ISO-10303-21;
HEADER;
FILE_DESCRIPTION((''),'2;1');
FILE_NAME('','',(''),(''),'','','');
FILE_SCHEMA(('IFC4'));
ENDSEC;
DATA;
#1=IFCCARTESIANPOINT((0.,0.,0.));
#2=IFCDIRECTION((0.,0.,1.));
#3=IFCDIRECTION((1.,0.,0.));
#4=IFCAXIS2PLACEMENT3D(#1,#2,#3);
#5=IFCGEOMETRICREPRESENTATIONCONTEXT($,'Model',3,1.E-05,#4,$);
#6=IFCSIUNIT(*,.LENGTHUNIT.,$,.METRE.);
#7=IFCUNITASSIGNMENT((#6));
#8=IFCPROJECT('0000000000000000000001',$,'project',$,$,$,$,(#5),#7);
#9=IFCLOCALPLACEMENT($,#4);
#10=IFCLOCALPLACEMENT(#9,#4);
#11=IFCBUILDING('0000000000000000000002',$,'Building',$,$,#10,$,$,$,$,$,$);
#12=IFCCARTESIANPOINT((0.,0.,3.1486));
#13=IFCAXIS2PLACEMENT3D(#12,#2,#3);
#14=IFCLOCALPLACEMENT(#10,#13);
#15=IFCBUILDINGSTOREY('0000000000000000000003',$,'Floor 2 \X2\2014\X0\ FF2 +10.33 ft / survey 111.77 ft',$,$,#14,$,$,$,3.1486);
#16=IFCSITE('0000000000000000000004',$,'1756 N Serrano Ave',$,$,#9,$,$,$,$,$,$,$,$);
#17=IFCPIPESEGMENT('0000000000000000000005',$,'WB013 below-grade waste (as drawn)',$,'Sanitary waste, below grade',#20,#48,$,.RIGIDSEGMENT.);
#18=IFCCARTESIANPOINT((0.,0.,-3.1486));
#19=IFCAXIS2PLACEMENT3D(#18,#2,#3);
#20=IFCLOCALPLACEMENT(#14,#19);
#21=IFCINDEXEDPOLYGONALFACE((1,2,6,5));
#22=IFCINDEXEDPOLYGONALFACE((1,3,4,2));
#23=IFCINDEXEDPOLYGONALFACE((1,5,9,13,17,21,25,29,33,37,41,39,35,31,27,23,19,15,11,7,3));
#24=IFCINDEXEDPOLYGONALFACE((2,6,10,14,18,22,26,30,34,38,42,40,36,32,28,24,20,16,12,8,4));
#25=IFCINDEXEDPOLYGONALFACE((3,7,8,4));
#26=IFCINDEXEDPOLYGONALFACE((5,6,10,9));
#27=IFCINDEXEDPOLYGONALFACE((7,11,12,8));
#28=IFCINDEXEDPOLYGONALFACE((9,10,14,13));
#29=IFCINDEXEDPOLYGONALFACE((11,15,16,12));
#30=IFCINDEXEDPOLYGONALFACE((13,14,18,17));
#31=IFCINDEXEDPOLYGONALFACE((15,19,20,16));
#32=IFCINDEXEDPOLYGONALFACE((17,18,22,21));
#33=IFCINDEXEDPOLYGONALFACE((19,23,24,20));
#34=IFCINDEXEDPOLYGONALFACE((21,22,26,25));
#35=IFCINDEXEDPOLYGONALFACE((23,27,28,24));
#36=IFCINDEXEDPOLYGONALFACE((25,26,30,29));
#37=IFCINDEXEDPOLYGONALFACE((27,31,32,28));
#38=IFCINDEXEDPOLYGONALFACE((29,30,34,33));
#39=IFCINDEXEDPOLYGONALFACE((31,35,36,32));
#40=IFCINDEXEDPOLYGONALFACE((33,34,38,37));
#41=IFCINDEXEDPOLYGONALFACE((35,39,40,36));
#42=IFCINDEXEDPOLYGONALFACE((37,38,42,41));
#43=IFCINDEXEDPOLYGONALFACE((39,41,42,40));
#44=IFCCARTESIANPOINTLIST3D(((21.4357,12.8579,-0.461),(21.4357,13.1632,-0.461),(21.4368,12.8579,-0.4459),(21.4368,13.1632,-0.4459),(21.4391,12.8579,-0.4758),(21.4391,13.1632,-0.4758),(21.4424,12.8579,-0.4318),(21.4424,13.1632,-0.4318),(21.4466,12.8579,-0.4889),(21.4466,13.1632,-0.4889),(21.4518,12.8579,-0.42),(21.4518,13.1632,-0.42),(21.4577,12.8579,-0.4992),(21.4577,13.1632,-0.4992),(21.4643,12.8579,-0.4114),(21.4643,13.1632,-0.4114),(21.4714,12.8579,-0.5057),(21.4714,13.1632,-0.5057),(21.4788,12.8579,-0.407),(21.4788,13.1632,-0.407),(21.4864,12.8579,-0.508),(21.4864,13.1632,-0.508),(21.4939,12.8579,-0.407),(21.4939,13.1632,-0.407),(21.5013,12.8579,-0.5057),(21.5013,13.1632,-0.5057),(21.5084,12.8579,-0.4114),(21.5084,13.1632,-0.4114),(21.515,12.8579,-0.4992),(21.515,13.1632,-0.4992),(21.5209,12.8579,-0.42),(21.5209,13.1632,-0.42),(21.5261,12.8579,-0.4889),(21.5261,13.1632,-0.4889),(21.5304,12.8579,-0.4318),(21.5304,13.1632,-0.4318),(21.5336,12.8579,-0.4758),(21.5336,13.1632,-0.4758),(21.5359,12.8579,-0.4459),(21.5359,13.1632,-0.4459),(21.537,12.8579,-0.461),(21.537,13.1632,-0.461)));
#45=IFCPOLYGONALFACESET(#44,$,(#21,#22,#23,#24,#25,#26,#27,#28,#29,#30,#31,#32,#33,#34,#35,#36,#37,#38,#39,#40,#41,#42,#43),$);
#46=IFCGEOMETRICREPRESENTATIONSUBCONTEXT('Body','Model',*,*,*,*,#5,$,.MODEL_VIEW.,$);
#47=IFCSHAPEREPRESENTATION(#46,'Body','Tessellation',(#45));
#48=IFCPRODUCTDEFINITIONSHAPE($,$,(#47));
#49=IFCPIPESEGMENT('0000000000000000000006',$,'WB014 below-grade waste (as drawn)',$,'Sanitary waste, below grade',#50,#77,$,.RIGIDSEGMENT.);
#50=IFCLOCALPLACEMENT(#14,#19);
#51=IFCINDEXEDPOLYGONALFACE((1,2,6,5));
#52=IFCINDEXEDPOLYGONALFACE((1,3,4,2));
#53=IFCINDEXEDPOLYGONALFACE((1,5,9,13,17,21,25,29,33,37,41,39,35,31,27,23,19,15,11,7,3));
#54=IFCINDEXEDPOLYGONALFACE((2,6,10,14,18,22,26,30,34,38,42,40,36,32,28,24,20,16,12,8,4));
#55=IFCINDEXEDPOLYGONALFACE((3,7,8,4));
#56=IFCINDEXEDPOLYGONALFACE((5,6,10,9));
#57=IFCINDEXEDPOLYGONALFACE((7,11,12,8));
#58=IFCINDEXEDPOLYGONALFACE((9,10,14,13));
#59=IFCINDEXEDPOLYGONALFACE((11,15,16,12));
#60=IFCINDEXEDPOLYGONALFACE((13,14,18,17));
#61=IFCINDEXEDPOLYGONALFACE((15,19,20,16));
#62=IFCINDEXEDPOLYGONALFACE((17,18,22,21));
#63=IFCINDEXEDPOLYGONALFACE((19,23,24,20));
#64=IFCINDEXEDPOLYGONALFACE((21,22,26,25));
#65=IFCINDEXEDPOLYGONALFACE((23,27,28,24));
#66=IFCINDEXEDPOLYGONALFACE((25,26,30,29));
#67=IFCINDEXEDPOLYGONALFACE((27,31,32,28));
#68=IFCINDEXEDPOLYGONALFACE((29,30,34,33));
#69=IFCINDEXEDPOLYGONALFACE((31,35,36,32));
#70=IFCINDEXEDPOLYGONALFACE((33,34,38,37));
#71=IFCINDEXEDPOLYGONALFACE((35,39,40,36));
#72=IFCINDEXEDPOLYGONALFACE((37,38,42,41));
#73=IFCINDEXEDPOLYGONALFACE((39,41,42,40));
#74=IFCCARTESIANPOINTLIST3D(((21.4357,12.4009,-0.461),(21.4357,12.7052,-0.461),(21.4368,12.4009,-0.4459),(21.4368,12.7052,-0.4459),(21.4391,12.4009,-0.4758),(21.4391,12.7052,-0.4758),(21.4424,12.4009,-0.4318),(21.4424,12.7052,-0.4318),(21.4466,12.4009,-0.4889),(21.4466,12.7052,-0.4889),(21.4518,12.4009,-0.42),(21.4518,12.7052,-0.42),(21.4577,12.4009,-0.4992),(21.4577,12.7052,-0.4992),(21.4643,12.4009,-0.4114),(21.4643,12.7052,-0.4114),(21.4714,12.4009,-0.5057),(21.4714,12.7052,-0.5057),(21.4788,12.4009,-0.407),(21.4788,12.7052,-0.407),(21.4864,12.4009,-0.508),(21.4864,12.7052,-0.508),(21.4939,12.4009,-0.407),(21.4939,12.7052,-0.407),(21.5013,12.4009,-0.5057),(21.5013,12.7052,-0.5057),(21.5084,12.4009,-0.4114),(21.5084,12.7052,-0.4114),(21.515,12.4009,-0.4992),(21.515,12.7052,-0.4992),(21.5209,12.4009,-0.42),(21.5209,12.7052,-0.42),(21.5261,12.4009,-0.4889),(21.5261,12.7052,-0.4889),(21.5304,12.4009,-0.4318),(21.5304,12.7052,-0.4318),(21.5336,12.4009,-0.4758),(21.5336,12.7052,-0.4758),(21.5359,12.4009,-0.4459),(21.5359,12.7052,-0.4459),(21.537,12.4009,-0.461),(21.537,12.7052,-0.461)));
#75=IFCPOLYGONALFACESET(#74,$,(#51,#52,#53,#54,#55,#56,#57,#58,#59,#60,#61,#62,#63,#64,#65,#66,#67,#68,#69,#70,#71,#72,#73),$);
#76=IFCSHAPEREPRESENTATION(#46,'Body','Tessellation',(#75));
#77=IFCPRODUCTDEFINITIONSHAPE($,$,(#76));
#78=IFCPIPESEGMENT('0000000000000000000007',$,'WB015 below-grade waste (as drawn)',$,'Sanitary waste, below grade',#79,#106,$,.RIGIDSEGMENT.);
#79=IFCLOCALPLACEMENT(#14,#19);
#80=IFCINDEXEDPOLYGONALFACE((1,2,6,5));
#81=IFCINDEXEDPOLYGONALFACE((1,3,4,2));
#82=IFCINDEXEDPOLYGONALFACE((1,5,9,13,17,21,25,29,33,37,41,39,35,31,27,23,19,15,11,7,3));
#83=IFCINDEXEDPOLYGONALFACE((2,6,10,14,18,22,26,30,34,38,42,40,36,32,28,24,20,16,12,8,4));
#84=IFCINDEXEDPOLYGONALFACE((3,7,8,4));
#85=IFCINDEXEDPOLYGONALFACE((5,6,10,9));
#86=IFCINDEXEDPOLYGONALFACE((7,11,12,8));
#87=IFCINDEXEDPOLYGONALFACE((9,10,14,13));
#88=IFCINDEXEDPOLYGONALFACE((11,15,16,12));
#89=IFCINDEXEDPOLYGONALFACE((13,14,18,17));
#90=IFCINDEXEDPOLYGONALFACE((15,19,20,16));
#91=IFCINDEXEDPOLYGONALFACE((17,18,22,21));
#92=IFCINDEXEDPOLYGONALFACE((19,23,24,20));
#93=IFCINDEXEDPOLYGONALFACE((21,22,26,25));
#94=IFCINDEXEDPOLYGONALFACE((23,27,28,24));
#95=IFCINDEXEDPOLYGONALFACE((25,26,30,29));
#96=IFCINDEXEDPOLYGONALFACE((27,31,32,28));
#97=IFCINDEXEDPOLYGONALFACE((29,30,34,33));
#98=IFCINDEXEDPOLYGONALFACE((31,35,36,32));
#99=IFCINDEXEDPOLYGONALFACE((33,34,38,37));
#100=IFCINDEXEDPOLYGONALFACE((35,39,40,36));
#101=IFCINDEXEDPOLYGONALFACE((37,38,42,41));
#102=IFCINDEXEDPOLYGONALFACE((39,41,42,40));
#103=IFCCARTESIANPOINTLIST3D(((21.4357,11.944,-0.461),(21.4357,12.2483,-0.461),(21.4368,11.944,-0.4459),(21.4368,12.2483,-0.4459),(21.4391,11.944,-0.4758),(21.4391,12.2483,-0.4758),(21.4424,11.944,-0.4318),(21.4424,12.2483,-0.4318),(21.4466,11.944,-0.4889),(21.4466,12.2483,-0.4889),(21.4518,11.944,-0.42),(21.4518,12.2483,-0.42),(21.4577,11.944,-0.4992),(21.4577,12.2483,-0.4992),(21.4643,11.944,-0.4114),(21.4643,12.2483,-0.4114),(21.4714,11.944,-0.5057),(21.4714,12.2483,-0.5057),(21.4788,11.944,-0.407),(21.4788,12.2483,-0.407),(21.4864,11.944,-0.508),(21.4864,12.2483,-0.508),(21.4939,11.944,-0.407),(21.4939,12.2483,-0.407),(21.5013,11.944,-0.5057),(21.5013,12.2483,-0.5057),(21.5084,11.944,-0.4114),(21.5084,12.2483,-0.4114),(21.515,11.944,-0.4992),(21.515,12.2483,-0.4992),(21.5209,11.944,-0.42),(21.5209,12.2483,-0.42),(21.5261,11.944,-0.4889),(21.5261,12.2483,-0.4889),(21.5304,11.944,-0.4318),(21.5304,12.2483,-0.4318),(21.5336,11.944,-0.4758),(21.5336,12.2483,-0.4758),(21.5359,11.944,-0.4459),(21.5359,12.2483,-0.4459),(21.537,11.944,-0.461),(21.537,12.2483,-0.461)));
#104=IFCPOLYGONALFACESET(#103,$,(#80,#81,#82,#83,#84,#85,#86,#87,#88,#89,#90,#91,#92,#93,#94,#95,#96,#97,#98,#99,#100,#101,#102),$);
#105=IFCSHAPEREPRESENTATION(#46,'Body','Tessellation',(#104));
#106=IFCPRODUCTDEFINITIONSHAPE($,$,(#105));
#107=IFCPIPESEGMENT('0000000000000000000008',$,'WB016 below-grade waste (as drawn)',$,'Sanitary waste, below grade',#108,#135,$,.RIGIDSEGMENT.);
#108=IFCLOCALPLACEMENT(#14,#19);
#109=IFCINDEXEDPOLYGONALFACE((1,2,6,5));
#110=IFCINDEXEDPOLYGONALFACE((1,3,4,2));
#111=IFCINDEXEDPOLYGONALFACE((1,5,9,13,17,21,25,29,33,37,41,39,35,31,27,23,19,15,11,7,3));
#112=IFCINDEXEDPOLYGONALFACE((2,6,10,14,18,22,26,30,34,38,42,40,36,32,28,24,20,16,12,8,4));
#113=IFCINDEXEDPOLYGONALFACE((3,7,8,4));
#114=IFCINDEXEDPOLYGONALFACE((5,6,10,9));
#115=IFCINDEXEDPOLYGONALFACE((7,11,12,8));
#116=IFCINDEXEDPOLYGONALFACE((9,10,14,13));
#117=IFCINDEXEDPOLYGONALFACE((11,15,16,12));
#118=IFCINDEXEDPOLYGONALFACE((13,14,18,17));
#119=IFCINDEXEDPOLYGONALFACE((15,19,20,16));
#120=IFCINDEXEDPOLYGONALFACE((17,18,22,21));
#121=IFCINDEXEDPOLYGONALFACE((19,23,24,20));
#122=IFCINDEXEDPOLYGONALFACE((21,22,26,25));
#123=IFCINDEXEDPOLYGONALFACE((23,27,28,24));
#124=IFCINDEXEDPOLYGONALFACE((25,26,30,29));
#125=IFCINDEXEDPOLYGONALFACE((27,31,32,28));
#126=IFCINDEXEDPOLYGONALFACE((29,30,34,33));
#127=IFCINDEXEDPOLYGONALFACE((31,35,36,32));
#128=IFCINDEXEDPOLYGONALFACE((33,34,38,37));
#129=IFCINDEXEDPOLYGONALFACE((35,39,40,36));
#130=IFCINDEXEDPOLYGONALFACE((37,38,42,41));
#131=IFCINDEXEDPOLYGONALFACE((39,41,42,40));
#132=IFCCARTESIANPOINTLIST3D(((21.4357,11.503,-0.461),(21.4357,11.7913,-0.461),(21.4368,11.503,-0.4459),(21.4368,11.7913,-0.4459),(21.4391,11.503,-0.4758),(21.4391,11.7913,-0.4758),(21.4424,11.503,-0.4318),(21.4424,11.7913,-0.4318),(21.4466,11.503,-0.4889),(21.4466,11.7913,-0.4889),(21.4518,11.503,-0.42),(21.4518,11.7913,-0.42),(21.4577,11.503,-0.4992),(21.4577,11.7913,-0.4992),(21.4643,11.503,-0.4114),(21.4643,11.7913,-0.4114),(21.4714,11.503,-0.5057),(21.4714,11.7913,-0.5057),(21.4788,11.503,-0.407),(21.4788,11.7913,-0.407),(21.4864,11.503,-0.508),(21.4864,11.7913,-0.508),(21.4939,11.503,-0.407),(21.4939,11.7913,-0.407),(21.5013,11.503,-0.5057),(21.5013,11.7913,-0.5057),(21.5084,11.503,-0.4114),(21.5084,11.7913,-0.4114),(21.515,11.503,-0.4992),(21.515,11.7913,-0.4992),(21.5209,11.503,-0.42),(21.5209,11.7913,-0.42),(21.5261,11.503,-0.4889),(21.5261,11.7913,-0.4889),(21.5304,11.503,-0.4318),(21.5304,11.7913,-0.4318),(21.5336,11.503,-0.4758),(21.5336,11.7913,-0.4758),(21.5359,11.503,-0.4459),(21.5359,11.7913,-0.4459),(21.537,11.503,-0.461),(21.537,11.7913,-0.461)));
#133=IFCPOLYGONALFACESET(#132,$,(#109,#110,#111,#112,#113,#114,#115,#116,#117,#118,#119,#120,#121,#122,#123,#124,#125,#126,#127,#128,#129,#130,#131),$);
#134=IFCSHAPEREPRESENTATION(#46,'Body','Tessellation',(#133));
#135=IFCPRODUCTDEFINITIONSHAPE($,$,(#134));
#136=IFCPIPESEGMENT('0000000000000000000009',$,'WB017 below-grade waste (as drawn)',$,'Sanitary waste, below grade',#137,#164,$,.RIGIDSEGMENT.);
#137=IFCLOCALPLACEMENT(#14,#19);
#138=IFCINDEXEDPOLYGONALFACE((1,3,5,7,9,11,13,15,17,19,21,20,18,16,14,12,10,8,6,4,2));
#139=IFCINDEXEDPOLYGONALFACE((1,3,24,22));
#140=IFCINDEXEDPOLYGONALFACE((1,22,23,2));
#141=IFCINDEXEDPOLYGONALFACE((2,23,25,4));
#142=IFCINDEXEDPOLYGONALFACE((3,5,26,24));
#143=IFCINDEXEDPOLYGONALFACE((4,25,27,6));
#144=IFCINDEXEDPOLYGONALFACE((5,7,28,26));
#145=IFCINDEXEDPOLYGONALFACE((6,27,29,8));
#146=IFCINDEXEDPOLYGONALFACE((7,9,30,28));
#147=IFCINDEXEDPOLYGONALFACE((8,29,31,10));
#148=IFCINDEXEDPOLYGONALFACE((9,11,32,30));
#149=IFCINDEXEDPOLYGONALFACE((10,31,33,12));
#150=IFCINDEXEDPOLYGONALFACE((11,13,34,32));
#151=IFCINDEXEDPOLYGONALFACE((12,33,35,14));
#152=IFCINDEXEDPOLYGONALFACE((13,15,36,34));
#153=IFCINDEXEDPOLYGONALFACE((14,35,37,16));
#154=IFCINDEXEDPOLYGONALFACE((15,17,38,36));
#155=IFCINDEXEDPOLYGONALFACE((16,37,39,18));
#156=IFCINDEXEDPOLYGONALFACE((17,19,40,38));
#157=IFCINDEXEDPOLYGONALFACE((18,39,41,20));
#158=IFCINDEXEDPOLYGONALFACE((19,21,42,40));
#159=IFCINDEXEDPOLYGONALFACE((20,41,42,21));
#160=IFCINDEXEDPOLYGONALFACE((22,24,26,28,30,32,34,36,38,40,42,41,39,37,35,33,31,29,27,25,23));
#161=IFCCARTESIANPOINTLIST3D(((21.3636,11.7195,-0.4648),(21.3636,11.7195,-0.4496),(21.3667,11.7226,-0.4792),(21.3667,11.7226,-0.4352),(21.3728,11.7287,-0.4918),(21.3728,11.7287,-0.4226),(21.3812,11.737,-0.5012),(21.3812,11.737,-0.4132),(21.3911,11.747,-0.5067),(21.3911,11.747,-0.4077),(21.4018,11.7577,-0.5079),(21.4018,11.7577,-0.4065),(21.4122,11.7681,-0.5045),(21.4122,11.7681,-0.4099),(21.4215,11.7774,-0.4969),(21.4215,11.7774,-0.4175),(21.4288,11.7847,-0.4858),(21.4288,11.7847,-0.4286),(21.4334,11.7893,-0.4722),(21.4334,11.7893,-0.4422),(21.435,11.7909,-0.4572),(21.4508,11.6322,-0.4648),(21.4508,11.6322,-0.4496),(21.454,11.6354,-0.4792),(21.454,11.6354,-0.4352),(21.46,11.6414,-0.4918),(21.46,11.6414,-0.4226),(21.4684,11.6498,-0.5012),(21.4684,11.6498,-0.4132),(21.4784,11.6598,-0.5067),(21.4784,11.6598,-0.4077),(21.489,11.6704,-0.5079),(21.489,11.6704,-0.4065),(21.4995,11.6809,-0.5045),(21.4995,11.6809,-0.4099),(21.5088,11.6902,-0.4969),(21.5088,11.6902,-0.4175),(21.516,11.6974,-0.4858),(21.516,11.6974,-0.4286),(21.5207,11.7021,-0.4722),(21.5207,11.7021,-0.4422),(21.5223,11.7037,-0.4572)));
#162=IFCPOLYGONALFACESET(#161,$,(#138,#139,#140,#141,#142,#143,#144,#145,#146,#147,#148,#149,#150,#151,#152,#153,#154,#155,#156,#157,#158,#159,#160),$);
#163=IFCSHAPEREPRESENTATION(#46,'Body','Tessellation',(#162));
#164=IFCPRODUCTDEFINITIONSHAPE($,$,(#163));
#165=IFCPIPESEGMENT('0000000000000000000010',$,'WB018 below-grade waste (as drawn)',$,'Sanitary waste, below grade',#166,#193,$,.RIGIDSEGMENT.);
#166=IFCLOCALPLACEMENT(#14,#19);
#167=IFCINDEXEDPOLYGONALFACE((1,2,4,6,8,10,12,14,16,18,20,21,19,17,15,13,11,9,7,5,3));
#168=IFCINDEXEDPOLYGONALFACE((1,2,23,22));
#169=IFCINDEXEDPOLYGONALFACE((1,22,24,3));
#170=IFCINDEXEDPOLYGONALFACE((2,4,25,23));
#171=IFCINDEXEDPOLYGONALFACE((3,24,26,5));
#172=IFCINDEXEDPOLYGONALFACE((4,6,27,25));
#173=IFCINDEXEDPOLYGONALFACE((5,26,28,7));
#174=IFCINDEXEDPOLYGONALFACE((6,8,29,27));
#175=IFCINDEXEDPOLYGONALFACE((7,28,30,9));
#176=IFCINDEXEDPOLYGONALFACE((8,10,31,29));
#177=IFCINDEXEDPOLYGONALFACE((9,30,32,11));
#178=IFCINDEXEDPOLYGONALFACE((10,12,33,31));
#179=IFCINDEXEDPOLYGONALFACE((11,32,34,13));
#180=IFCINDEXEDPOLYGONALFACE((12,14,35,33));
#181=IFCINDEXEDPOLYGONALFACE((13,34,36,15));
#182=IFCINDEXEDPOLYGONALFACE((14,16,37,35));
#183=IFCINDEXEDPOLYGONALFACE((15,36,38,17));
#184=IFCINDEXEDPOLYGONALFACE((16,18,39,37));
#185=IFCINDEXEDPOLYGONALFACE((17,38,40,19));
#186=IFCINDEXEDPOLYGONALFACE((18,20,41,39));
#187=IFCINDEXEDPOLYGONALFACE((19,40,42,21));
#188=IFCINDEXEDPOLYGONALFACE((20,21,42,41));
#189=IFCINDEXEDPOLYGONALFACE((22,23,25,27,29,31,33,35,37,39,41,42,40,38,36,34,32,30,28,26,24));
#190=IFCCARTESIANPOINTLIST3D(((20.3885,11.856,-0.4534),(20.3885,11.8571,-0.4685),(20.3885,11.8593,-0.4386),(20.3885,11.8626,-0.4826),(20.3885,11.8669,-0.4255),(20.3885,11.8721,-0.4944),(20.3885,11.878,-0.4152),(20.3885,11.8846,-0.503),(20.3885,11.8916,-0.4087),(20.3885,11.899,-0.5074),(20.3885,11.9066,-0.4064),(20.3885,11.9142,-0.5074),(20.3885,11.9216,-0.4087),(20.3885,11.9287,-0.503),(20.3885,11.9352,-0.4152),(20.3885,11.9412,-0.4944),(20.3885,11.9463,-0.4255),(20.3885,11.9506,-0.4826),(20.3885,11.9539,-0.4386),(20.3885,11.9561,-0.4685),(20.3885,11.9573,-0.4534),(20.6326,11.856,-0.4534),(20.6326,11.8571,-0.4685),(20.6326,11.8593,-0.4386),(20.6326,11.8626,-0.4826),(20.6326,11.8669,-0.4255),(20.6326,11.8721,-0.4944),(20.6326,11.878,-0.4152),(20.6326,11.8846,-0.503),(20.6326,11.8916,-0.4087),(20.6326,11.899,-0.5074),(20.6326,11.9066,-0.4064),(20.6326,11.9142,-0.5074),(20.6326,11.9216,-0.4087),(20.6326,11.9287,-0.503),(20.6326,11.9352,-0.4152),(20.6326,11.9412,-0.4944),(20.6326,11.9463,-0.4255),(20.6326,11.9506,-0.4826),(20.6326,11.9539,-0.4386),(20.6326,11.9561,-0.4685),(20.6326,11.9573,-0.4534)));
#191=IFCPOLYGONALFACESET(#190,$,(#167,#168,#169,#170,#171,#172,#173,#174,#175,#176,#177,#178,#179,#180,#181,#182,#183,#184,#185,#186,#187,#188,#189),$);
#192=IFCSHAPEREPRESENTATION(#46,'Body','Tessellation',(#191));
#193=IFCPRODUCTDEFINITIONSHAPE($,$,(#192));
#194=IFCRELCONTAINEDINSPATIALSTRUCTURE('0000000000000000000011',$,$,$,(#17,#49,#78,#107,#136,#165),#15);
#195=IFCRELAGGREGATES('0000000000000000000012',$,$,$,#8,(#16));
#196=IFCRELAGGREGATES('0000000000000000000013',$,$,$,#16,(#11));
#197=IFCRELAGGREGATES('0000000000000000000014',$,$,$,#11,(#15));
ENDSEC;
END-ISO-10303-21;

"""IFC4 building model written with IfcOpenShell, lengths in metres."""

from ifc_helpers import new_model, entity, si_unit, frame, origin_with_axes, place, context, subcontext, project, spatial, element, save


model = new_model("IFC4")

# Units and contexts
model_context = context("Model", 3, precision=1e-05, world=origin_with_axes())
body_context = subcontext(model_context, "Body", "Model", "MODEL_VIEW")
ifc_project = project(units=[si_unit("LENGTHUNIT", "METRE")], contexts=[model_context])

# Site, building, storey
site_placement = place(None, origin_with_axes())
site = spatial("IfcSite", under=ifc_project, at=site_placement, Name="1756 N Serrano Ave")
building_placement = place(site_placement, origin_with_axes())
building = spatial("IfcBuilding", under=site, at=building_placement, Name="Building")
storey_placement = place(building_placement, frame((0.0, 0.0, 3.1486), z_axis=(0.0, 0.0, 1.0), x_axis=(1.0, 0.0, 0.0)))
storey = spatial("IfcBuildingStorey", under=building, at=storey_placement, Name="Floor 2 — FF2 +10.33 ft / survey 111.77 ft", Elevation=3.1486)

# Pipe segments
pipe_segment_1_placement = place(storey_placement, frame((0.0, 0.0, -3.1486), z_axis=(0.0, 0.0, 1.0), x_axis=(1.0, 0.0, 0.0)))
element("IfcPipeSegment", 1, at=pipe_segment_1_placement, inside=storey, Name="WB013 below-grade waste (as drawn)", ObjectType="Sanitary waste, below grade", PredefinedType="RIGIDSEGMENT", context=body_context, shape_type="AdvancedSweptSolid", body=[
    entity("IfcSweptDiskSolid", entity("IfcPolyline", [entity("IfcCartesianPoint", [21.4864, 13.1632, -0.4572]), entity("IfcCartesianPoint", [21.4864, 12.8579, -0.4572])]), 0.0508),
])
pipe_segment_2_placement = place(storey_placement, frame((0.0, 0.0, -3.1486), z_axis=(0.0, 0.0, 1.0), x_axis=(1.0, 0.0, 0.0)))
element("IfcPipeSegment", 2, at=pipe_segment_2_placement, inside=storey, Name="WB014 below-grade waste (as drawn)", ObjectType="Sanitary waste, below grade", PredefinedType="RIGIDSEGMENT", context=body_context, shape_type="AdvancedSweptSolid", body=[
    entity("IfcSweptDiskSolid", entity("IfcPolyline", [entity("IfcCartesianPoint", [21.4864, 12.7052, -0.4572]), entity("IfcCartesianPoint", [21.4864, 12.4009, -0.4572])]), 0.0508),
])
pipe_segment_3_placement = place(storey_placement, frame((0.0, 0.0, -3.1486), z_axis=(0.0, 0.0, 1.0), x_axis=(1.0, 0.0, 0.0)))
element("IfcPipeSegment", 3, at=pipe_segment_3_placement, inside=storey, Name="WB015 below-grade waste (as drawn)", ObjectType="Sanitary waste, below grade", PredefinedType="RIGIDSEGMENT", context=body_context, shape_type="AdvancedSweptSolid", body=[
    entity("IfcSweptDiskSolid", entity("IfcPolyline", [entity("IfcCartesianPoint", [21.4864, 12.2483, -0.4572]), entity("IfcCartesianPoint", [21.4864, 11.944, -0.4572])]), 0.0508),
])
pipe_segment_4_placement = place(storey_placement, frame((0.0, 0.0, -3.1486), z_axis=(0.0, 0.0, 1.0), x_axis=(1.0, 0.0, 0.0)))
element("IfcPipeSegment", 4, at=pipe_segment_4_placement, inside=storey, Name="WB016 below-grade waste (as drawn)", ObjectType="Sanitary waste, below grade", PredefinedType="RIGIDSEGMENT", context=body_context, shape_type="AdvancedSweptSolid", body=[
    entity("IfcSweptDiskSolid", entity("IfcPolyline", [entity("IfcCartesianPoint", [21.4864, 11.7913, -0.4572]), entity("IfcCartesianPoint", [21.4864, 11.503, -0.4572])]), 0.0508),
])
pipe_segment_5_placement = place(storey_placement, frame((0.0, 0.0, -3.1486), z_axis=(0.0, 0.0, 1.0), x_axis=(1.0, 0.0, 0.0)))
element("IfcPipeSegment", 5, at=pipe_segment_5_placement, inside=storey, Name="WB017 below-grade waste (as drawn)", ObjectType="Sanitary waste, below grade", PredefinedType="RIGIDSEGMENT", context=body_context, shape_type="AdvancedSweptSolid", body=[
    entity("IfcSweptDiskSolid", entity("IfcPolyline", [entity("IfcCartesianPoint", [21.3991, 11.755, -0.4572]), entity("IfcCartesianPoint", [21.4864, 11.6678, -0.4572])]), 0.0508),
])
pipe_segment_6_placement = place(storey_placement, frame((0.0, 0.0, -3.1486), z_axis=(0.0, 0.0, 1.0), x_axis=(1.0, 0.0, 0.0)))
element("IfcPipeSegment", 6, at=pipe_segment_6_placement, inside=storey, Name="WB018 below-grade waste (as drawn)", ObjectType="Sanitary waste, below grade", PredefinedType="RIGIDSEGMENT", context=body_context, shape_type="AdvancedSweptSolid", body=[
    entity("IfcSweptDiskSolid", entity("IfcPolyline", [entity("IfcCartesianPoint", [20.3885, 11.9066, -0.4572]), entity("IfcCartesianPoint", [20.6326, 11.9066, -0.4572])]), 0.0508),
])

save(model, "model.ifc")
